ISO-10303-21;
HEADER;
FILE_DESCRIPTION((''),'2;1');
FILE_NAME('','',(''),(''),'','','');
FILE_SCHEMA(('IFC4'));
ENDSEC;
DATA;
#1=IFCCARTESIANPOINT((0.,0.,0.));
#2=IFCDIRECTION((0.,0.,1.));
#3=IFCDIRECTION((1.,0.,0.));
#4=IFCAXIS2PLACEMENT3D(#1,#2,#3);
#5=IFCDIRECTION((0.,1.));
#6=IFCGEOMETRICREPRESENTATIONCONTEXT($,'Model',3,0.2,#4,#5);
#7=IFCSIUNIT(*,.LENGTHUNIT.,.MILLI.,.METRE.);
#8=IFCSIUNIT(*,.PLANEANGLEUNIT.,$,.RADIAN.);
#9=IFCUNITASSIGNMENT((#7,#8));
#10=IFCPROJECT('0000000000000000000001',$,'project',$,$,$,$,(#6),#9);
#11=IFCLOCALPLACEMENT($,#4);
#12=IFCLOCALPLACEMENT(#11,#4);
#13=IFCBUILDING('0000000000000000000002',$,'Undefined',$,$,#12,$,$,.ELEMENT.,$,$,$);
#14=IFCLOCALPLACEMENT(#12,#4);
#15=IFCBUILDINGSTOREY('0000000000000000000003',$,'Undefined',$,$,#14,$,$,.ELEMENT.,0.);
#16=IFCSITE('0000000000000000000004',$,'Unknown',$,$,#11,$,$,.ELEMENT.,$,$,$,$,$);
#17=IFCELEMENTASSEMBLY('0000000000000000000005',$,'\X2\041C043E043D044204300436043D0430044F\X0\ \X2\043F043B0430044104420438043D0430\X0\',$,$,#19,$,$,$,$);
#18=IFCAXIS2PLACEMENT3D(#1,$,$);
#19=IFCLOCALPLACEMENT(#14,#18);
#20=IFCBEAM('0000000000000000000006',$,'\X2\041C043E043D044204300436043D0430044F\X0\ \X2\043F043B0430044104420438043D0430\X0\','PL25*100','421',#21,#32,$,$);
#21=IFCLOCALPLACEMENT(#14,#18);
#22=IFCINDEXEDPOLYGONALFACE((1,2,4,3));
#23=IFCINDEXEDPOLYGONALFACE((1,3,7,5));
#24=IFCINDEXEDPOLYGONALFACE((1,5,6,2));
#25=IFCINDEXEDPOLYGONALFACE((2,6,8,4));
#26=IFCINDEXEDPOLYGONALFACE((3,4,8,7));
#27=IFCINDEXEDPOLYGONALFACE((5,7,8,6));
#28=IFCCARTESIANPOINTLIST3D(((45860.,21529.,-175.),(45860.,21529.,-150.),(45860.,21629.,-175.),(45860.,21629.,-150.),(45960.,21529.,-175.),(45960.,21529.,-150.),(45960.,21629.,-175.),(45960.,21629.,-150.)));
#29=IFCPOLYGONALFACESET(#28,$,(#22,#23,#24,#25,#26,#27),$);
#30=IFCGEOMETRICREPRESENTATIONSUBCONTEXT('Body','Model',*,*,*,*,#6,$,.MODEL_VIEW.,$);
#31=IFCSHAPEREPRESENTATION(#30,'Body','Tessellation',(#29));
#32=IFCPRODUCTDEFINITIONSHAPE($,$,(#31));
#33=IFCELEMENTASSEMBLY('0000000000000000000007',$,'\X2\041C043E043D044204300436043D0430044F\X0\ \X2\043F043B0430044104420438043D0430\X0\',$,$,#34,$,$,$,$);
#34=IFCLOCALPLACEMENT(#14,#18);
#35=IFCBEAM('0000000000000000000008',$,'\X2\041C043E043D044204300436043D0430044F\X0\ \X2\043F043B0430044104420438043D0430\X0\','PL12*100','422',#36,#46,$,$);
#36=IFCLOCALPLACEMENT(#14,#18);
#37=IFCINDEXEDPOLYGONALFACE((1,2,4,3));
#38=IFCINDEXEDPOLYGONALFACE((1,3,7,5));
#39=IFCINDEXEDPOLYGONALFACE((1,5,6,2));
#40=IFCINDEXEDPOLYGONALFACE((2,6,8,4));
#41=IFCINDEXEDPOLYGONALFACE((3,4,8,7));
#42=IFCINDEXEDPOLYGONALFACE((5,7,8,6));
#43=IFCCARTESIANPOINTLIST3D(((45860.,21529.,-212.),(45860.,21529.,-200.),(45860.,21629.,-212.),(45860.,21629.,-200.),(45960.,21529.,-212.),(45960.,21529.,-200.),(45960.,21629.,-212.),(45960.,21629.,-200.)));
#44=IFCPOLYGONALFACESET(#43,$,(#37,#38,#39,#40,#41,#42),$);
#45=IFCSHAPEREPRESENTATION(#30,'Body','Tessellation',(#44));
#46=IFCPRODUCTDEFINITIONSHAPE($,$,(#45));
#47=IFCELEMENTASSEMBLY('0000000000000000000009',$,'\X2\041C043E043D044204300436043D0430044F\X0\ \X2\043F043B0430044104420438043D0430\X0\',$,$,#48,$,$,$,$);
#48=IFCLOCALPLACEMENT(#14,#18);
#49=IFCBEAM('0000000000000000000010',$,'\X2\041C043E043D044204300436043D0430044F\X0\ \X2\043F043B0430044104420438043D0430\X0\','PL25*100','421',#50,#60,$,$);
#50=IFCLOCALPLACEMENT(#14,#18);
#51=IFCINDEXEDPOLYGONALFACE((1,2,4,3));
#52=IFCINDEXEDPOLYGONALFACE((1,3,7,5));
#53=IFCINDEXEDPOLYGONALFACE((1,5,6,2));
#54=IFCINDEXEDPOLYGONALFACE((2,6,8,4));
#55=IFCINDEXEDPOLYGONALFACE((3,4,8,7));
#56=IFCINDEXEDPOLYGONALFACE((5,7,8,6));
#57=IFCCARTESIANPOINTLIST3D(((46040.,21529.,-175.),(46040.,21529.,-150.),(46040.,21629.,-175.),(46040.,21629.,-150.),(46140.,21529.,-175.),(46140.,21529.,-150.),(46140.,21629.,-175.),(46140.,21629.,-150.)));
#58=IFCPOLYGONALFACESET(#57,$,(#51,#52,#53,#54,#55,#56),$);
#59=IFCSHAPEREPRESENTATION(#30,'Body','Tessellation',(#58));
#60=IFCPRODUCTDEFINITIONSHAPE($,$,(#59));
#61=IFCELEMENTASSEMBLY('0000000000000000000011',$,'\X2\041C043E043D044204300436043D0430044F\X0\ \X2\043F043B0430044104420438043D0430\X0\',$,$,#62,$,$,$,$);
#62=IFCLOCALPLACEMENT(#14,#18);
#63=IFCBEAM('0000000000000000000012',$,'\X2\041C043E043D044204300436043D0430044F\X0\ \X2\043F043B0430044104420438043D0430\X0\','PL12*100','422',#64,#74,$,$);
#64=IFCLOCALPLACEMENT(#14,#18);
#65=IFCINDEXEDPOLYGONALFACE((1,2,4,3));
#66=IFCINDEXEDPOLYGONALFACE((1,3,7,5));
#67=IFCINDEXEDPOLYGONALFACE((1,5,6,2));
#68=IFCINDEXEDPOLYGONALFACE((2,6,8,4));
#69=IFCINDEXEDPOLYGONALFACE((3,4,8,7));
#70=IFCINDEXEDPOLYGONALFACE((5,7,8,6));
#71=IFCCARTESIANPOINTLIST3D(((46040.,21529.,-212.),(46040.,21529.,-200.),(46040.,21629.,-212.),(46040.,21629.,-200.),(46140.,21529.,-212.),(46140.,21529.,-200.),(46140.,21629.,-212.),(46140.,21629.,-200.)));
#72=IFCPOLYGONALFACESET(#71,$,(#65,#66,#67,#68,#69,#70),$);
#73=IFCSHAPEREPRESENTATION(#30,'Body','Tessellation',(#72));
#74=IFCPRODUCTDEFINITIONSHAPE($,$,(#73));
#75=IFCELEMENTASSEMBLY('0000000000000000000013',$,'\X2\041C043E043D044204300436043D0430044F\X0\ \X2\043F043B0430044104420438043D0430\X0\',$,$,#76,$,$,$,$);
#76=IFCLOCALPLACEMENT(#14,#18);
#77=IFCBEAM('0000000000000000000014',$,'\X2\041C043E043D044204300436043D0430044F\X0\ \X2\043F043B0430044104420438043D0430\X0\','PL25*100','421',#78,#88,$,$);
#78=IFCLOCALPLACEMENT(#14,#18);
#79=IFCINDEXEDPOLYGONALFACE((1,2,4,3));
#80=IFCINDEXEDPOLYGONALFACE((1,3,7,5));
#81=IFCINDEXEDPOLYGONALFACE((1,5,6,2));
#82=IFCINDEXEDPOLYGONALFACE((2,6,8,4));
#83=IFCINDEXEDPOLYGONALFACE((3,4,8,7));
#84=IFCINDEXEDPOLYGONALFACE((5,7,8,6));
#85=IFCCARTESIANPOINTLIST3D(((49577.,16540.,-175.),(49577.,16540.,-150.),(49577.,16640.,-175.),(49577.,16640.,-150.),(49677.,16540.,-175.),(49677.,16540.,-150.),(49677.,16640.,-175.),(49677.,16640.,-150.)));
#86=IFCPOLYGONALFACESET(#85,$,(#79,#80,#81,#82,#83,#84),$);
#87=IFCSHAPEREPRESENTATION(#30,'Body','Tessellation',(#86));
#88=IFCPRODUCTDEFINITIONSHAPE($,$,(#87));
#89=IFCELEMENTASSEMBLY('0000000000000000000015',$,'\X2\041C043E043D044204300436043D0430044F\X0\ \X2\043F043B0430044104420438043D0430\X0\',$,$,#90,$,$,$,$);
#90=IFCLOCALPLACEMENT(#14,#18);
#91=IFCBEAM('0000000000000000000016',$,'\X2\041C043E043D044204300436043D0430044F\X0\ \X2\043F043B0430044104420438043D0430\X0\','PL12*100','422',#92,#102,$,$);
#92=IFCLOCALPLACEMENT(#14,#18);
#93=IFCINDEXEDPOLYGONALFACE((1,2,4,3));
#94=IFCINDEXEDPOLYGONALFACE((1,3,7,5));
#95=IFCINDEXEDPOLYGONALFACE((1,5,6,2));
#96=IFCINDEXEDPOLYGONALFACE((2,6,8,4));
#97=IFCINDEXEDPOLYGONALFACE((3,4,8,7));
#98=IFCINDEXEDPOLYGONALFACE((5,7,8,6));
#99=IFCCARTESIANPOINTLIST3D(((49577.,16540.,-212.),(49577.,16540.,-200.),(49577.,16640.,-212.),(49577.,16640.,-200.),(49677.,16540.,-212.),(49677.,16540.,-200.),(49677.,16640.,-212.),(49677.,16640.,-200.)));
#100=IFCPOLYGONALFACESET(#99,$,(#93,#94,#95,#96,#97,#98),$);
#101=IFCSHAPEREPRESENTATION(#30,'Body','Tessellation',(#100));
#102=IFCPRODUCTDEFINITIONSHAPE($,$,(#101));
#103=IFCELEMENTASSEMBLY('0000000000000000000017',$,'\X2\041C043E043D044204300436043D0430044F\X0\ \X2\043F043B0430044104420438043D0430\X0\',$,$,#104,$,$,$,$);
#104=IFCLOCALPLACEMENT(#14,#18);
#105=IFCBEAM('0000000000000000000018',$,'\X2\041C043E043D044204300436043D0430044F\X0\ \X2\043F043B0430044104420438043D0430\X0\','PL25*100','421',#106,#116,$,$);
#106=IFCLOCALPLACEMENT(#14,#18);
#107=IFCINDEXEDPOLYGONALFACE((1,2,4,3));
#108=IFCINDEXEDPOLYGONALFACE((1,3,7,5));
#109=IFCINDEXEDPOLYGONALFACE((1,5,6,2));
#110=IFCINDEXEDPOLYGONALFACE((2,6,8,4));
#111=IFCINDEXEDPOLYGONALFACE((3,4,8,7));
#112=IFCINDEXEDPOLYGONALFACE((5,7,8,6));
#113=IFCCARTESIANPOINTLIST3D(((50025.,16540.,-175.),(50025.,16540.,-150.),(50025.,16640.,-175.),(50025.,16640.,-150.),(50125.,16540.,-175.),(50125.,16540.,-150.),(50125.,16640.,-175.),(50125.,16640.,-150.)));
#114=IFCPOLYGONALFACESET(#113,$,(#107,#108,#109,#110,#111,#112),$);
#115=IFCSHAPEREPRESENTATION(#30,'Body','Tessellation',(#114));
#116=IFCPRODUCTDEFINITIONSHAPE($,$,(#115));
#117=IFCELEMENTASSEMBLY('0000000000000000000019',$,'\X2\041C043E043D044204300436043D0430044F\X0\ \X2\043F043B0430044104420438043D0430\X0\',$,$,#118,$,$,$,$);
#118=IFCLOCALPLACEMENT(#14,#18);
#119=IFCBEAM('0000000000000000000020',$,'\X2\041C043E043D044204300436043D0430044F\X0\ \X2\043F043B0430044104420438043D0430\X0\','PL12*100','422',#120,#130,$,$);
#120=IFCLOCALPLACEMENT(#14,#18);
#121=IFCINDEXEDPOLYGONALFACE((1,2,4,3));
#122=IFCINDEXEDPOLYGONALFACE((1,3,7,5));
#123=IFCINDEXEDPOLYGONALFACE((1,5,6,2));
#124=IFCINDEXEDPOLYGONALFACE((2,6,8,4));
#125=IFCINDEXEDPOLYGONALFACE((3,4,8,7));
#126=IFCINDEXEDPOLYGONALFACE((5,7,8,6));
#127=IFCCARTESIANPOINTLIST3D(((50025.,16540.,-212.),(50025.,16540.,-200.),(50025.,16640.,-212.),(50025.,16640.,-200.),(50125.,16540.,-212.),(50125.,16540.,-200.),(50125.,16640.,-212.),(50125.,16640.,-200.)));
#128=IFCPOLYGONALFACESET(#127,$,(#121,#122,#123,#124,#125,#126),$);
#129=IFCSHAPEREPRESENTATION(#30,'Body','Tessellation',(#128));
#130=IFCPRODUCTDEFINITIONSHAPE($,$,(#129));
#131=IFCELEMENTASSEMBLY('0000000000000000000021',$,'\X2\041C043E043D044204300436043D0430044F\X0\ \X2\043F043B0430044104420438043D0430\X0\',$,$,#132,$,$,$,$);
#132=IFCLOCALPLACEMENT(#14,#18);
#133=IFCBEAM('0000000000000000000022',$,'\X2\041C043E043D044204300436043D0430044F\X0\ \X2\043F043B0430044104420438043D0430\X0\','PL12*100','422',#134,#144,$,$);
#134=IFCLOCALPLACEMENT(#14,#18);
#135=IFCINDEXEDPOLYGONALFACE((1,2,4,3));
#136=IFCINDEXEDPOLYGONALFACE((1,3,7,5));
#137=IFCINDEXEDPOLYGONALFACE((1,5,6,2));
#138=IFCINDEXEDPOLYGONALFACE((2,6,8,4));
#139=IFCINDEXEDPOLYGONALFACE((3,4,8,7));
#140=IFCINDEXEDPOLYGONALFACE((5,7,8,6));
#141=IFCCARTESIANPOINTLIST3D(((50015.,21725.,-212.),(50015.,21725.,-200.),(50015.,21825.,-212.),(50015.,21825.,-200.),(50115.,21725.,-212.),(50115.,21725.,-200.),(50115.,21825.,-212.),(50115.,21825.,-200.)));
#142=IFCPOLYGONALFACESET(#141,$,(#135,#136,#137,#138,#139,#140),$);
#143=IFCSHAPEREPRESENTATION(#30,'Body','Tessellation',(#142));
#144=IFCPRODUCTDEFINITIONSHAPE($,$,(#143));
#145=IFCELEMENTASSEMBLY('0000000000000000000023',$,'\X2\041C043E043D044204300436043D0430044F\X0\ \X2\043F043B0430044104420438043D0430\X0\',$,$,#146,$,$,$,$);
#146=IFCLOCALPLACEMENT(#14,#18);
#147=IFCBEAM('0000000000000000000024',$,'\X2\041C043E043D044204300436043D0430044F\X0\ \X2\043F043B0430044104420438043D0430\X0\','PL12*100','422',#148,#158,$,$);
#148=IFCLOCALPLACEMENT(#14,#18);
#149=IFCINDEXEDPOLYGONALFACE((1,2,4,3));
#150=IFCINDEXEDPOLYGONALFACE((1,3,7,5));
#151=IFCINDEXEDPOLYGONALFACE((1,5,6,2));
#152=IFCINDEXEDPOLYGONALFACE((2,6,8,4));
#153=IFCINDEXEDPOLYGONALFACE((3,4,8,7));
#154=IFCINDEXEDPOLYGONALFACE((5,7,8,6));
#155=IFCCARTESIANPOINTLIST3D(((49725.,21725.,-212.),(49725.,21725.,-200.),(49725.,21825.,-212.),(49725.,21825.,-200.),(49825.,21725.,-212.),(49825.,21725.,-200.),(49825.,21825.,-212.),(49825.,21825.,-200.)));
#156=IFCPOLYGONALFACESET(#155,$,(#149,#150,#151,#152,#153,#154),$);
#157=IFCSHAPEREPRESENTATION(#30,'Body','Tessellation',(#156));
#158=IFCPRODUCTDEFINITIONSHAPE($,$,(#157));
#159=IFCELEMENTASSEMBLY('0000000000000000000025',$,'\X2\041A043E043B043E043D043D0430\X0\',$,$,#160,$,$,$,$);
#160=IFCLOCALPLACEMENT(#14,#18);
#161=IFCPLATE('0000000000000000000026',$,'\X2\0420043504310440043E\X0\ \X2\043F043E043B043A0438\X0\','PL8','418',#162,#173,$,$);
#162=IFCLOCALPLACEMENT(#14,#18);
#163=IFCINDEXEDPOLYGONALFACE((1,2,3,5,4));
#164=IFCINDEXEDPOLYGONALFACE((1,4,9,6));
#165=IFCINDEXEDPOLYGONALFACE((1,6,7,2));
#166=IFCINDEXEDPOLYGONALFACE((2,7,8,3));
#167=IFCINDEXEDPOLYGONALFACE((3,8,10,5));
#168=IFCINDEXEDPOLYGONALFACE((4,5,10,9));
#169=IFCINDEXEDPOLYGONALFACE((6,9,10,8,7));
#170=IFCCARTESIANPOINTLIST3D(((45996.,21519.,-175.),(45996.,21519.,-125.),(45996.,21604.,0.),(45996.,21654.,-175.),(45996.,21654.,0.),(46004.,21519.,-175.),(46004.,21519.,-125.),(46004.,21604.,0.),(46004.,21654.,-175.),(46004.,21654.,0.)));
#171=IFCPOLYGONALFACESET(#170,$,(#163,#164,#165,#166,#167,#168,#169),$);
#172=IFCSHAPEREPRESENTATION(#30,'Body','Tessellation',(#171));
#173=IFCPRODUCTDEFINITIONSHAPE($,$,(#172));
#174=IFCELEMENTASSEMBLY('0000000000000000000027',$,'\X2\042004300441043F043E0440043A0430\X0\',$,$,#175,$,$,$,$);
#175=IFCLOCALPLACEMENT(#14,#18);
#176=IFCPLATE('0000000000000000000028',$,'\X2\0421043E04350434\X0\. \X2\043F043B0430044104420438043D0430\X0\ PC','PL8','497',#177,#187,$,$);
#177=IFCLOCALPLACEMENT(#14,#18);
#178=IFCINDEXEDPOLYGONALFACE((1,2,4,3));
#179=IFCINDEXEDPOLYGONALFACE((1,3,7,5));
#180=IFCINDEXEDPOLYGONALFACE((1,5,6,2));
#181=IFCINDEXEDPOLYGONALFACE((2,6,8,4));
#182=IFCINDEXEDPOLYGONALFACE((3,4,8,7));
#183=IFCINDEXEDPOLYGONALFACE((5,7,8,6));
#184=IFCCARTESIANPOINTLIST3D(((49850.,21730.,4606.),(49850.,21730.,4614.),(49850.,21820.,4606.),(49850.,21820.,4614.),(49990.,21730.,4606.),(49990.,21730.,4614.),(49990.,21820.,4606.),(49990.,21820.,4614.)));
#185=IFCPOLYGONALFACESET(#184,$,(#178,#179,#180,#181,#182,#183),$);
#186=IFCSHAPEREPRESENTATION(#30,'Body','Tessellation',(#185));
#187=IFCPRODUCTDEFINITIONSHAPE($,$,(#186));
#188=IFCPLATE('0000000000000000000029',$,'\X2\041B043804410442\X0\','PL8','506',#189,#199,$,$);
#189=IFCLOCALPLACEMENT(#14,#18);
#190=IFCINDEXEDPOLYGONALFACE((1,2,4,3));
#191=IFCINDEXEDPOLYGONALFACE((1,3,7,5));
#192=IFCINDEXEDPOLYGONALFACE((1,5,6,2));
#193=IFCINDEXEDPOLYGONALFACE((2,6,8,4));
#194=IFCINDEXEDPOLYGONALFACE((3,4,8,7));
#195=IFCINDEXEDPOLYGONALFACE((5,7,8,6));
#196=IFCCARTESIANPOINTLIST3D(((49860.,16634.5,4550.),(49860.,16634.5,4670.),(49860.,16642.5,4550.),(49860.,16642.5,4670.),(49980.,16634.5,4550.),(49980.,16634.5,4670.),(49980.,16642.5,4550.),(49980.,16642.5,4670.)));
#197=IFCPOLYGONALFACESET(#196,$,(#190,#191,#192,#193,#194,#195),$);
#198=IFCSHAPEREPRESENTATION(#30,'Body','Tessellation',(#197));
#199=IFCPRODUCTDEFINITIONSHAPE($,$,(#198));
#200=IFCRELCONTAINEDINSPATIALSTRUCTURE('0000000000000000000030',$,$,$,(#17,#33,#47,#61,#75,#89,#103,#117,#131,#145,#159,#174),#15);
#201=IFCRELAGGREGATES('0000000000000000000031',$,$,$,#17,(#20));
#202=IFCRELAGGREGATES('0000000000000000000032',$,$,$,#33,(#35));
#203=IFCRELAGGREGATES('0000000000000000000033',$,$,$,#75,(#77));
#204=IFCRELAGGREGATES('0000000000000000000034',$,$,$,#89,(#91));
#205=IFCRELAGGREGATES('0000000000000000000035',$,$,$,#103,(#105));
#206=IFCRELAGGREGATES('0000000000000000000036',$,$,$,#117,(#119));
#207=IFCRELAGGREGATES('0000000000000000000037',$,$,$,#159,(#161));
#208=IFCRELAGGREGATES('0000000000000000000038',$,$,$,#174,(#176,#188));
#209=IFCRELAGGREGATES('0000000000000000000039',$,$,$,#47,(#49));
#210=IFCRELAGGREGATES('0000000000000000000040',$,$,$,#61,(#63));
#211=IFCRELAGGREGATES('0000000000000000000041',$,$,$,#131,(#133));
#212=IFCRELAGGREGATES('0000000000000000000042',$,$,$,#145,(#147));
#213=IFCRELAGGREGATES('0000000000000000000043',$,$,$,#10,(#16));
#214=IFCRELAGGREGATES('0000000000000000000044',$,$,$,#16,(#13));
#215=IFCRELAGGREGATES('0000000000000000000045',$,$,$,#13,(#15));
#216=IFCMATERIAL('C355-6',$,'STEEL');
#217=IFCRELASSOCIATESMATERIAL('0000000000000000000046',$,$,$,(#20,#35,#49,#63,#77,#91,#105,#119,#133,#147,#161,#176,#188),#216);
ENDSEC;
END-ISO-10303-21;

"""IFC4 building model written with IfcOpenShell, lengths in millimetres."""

from ifc_helpers import new_model, si_unit, direction, frame, origin_with_axes, place, context, subcontext, project, spatial, line, indexed_curve, outline, extrude, material, element, aggregate, save


model = new_model("IFC4")

# Units and contexts
model_context = context("Model", 3, precision=0.2, world=origin_with_axes(), true_north=direction((0.0, 1.0)))
body_context = subcontext(model_context, "Body", "Model", "MODEL_VIEW")
ifc_project = project(units=[si_unit("LENGTHUNIT", "METRE", prefix="MILLI"), si_unit("PLANEANGLEUNIT", "RADIAN")], contexts=[model_context])

# Site, building, storey
site_placement = place(None, origin_with_axes())
site = spatial("IfcSite", under=ifc_project, at=site_placement, Name="Unknown", CompositionType="ELEMENT")
building_placement = place(site_placement, origin_with_axes())
building = spatial("IfcBuilding", under=site, at=building_placement, Name="Undefined", CompositionType="ELEMENT")
storey_placement = place(building_placement, origin_with_axes())
storey = spatial("IfcBuildingStorey", under=building, at=storey_placement, Name="Undefined", CompositionType="ELEMENT", Elevation=0.0)

# Element assemblies, beams
assembly_1_placement = place(storey_placement, frame((45960.0, 21579.0, -162.5), z_axis=(0.0, 0.0, -1.0), x_axis=(-1.0, 0.0, 0.0)))
assembly_1 = element("IfcElementAssembly", 1, at=assembly_1_placement, inside=storey, Name="Монтажная пластина")
ifc_material_1 = material(Name="C355-6", Category="STEEL")
beam_1_placement = place(assembly_1_placement, origin_with_axes())
beam_1 = element("IfcBeam", 2, at=beam_1_placement, material=ifc_material_1, Name="Монтажная пластина", Description="PL25*100", ObjectType="421", context=body_context, shape_type="SolidModel", body=[
    extrude(outline(indexed_curve([(-12.5, -50.0), (12.5, -50.0), (12.5, 50.0), (-12.5, 50.0)], segments=[line(1, 2, 3, 4, 1)])), frame((0.0, 0.0, 0.0), z_axis=(-1.0, 0.0, 0.0), x_axis=(0.0, 0.0, 1.0)), (0.0, 0.0, -1.0), 100.0),
])
aggregate(assembly_1, [beam_1])
assembly_2_placement = place(storey_placement, frame((45960.0, 21579.0, -206.0), z_axis=(0.0, 0.0, -1.0), x_axis=(-1.0, 0.0, 0.0)))
assembly_2 = element("IfcElementAssembly", 3, at=assembly_2_placement, inside=storey, Name="Монтажная пластина")
beam_2_placement = place(assembly_2_placement, origin_with_axes())
beam_2 = element("IfcBeam", 4, at=beam_2_placement, material=ifc_material_1, Name="Монтажная пластина", Description="PL12*100", ObjectType="422", context=body_context, shape_type="SolidModel", body=[
    extrude(outline(indexed_curve([(-6.0, -50.0), (6.0, -50.0), (6.0, 50.0), (-6.0, 50.0)], segments=[line(1, 2, 3, 4, 1)])), frame((0.0, 0.0, 0.0), z_axis=(-1.0, 0.0, 0.0), x_axis=(0.0, 0.0, 1.0)), (0.0, 0.0, -1.0), 100.0),
])
aggregate(assembly_2, [beam_2])
assembly_3_placement = place(storey_placement, frame((46140.0, 21579.0, -162.5), z_axis=(0.0, 0.0, -1.0), x_axis=(-1.0, 0.0, 0.0)))
assembly_3 = element("IfcElementAssembly", 5, at=assembly_3_placement, inside=storey, Name="Монтажная пластина")
beam_3_placement = place(assembly_3_placement, origin_with_axes())
beam_3 = element("IfcBeam", 6, at=beam_3_placement, material=ifc_material_1, Name="Монтажная пластина", Description="PL25*100", ObjectType="421", context=body_context, shape_type="SolidModel", body=[
    extrude(outline(indexed_curve([(-12.5, -50.0), (12.5, -50.0), (12.5, 50.0), (-12.5, 50.0)], segments=[line(1, 2, 3, 4, 1)])), frame((0.0, 0.0, 0.0), z_axis=(-1.0, 0.0, 0.0), x_axis=(0.0, 0.0, 1.0)), (0.0, 0.0, -1.0), 100.0),
])
assembly_4_placement = place(storey_placement, frame((46140.0, 21579.0, -206.0), z_axis=(0.0, 0.0, -1.0), x_axis=(-1.0, 0.0, 0.0)))
assembly_4 = element("IfcElementAssembly", 7, at=assembly_4_placement, inside=storey, Name="Монтажная пластина")
beam_4_placement = place(assembly_4_placement, origin_with_axes())
beam_4 = element("IfcBeam", 8, at=beam_4_placement, material=ifc_material_1, Name="Монтажная пластина", Description="PL12*100", ObjectType="422", context=body_context, shape_type="SolidModel", body=[
    extrude(outline(indexed_curve([(-6.0, -50.0), (6.0, -50.0), (6.0, 50.0), (-6.0, 50.0)], segments=[line(1, 2, 3, 4, 1)])), frame((0.0, 0.0, 0.0), z_axis=(-1.0, 0.0, 0.0), x_axis=(0.0, 0.0, 1.0)), (0.0, 0.0, -1.0), 100.0),
])
assembly_5_placement = place(storey_placement, frame((49627.0, 16640.0, -162.5), z_axis=(0.0, 0.0, -1.0), x_axis=(0.0, -1.0, 0.0)))
assembly_5 = element("IfcElementAssembly", 9, at=assembly_5_placement, inside=storey, Name="Монтажная пластина")
beam_5_placement = place(assembly_5_placement, origin_with_axes())
beam_5 = element("IfcBeam", 10, at=beam_5_placement, material=ifc_material_1, Name="Монтажная пластина", Description="PL25*100", ObjectType="421", context=body_context, shape_type="SolidModel", body=[
    extrude(outline(indexed_curve([(-12.5, -50.0), (12.5, -50.0), (12.5, 50.0), (-12.5, 50.0)], segments=[line(1, 2, 3, 4, 1)])), frame((0.0, 0.0, 0.0), z_axis=(-1.0, 0.0, 0.0), x_axis=(0.0, 0.0, 1.0)), (0.0, 0.0, -1.0), 100.0),
])
aggregate(assembly_5, [beam_5])
assembly_6_placement = place(storey_placement, frame((49627.0, 16640.0, -206.0), z_axis=(0.0, 0.0, -1.0), x_axis=(0.0, -1.0, 0.0)))
assembly_6 = element("IfcElementAssembly", 11, at=assembly_6_placement, inside=storey, Name="Монтажная пластина")
beam_6_placement = place(assembly_6_placement, origin_with_axes())
beam_6 = element("IfcBeam", 12, at=beam_6_placement, material=ifc_material_1, Name="Монтажная пластина", Description="PL12*100", ObjectType="422", context=body_context, shape_type="SolidModel", body=[
    extrude(outline(indexed_curve([(-6.0, -50.0), (6.0, -50.0), (6.0, 50.0), (-6.0, 50.0)], segments=[line(1, 2, 3, 4, 1)])), frame((0.0, 0.0, 0.0), z_axis=(-1.0, 0.0, 0.0), x_axis=(0.0, 0.0, 1.0)), (0.0, 0.0, -1.0), 100.0),
])
aggregate(assembly_6, [beam_6])
assembly_7_placement = place(storey_placement, frame((50075.0, 16640.0, -162.5), z_axis=(0.0, 0.0, -1.0), x_axis=(0.0, -1.0, 0.0)))
assembly_7 = element("IfcElementAssembly", 13, at=assembly_7_placement, inside=storey, Name="Монтажная пластина")
beam_7_placement = place(assembly_7_placement, origin_with_axes())
beam_7 = element("IfcBeam", 14, at=beam_7_placement, material=ifc_material_1, Name="Монтажная пластина", Description="PL25*100", ObjectType="421", context=body_context, shape_type="SolidModel", body=[
    extrude(outline(indexed_curve([(-12.5, -50.0), (12.5, -50.0), (12.5, 50.0), (-12.5, 50.0)], segments=[line(1, 2, 3, 4, 1)])), frame((0.0, 0.0, 0.0), z_axis=(-1.0, 0.0, 0.0), x_axis=(0.0, 0.0, 1.0)), (0.0, 0.0, -1.0), 100.0),
])
aggregate(assembly_7, [beam_7])
assembly_8_placement = place(storey_placement, frame((50075.0, 16640.0, -206.0), z_axis=(0.0, 0.0, -1.0), x_axis=(0.0, -1.0, 0.0)))
assembly_8 = element("IfcElementAssembly", 15, at=assembly_8_placement, inside=storey, Name="Монтажная пластина")
beam_8_placement = place(assembly_8_placement, origin_with_axes())
beam_8 = element("IfcBeam", 16, at=beam_8_placement, material=ifc_material_1, Name="Монтажная пластина", Description="PL12*100", ObjectType="422", context=body_context, shape_type="SolidModel", body=[
    extrude(outline(indexed_curve([(-6.0, -50.0), (6.0, -50.0), (6.0, 50.0), (-6.0, 50.0)], segments=[line(1, 2, 3, 4, 1)])), frame((0.0, 0.0, 0.0), z_axis=(-1.0, 0.0, 0.0), x_axis=(0.0, 0.0, 1.0)), (0.0, 0.0, -1.0), 100.0),
])
aggregate(assembly_8, [beam_8])
assembly_9_placement = place(storey_placement, frame((50015.0, 21775.0, -206.0), z_axis=(0.0, 0.0, -1.0), x_axis=(1.0, 0.0, 0.0)))
assembly_9 = element("IfcElementAssembly", 17, at=assembly_9_placement, inside=storey, Name="Монтажная пластина")
beam_9_placement = place(assembly_9_placement, origin_with_axes())
beam_9 = element("IfcBeam", 18, at=beam_9_placement, material=ifc_material_1, Name="Монтажная пластина", Description="PL12*100", ObjectType="422", context=body_context, shape_type="SolidModel", body=[
    extrude(outline(indexed_curve([(-6.0, -50.0), (6.0, -50.0), (6.0, 50.0), (-6.0, 50.0)], segments=[line(1, 2, 3, 4, 1)])), frame((0.0, 0.0, 0.0), z_axis=(-1.0, 0.0, 0.0), x_axis=(0.0, 0.0, 1.0)), (0.0, 0.0, -1.0), 100.0),
])
assembly_10_placement = place(storey_placement, frame((49725.0, 21775.0, -206.0), z_axis=(0.0, 0.0, -1.0), x_axis=(1.0, 0.0, 0.0)))
assembly_10 = element("IfcElementAssembly", 19, at=assembly_10_placement, inside=storey, Name="Монтажная пластина")
beam_10_placement = place(assembly_10_placement, origin_with_axes())
beam_10 = element("IfcBeam", 20, at=beam_10_placement, material=ifc_material_1, Name="Монтажная пластина", Description="PL12*100", ObjectType="422", context=body_context, shape_type="SolidModel", body=[
    extrude(outline(indexed_curve([(-6.0, -50.0), (6.0, -50.0), (6.0, 50.0), (-6.0, 50.0)], segments=[line(1, 2, 3, 4, 1)])), frame((0.0, 0.0, 0.0), z_axis=(-1.0, 0.0, 0.0), x_axis=(0.0, 0.0, 1.0)), (0.0, 0.0, -1.0), 100.0),
])

# Element assembly, plate
assembly_11_placement = place(storey_placement, frame((46000.0, 21827.0, -200.0), z_axis=(-1.0, 0.0, 0.0), x_axis=(0.0, 0.0, 1.0)))
assembly_11 = element("IfcElementAssembly", 21, at=assembly_11_placement, inside=storey, Name="Колонна")
plate_1_placement = place(assembly_11_placement, frame((25.0, -173.0, 0.0), z_axis=(0.0, 0.0, 1.0), x_axis=(0.0, -1.0, 0.0)))
plate_1 = element("IfcPlate", 22, at=plate_1_placement, material=ifc_material_1, Name="Ребро полки", Description="PL8", ObjectType="418", context=body_context, shape_type="SolidModel", body=[
    extrude(outline(indexed_curve([(0.0, 0.0), (135.0, 0.0), (135.0, 50.0), (50.0, 175.0), (0.0, 175.0)], segments=[line(1, 2, 3, 4, 5, 1)])), frame((0.0, 0.0, 4.0), z_axis=(0.0, 0.0, 1.0), x_axis=(1.0, 0.0, 0.0)), (0.0, 0.0, -1.0), 8.0),
])
aggregate(assembly_11, [plate_1])

# Element assembly, plates
assembly_12_placement = place(storey_placement, frame((49920.0, 16500.0, 4610.0), z_axis=(0.0, 0.0, -1.0), x_axis=(0.0, 1.0, 0.0)))
assembly_12 = element("IfcElementAssembly", 23, at=assembly_12_placement, inside=storey, Name="Распорка")
plate_2_placement = place(assembly_12_placement, frame((5230.0, 70.0, 0.0), z_axis=(0.0, 0.0, -1.0), x_axis=(1.0, 0.0, 0.0)))
plate_2 = element("IfcPlate", 24, at=plate_2_placement, material=ifc_material_1, Name="Соед. пластина PC", Description="PL8", ObjectType="497", context=body_context, shape_type="SolidModel", body=[
    extrude(outline(indexed_curve([(0.0, 0.0), (90.0, 0.0), (90.0, 140.0), (0.0, 140.0)], segments=[line(1, 2, 3, 4, 1)])), frame((0.0, 0.0, 4.0), z_axis=(0.0, 0.0, 1.0), x_axis=(1.0, 0.0, 0.0)), (0.0, 0.0, -1.0), 8.0),
])
plate_3_placement = place(assembly_12_placement, frame((138.5, 60.0, 60.0), z_axis=(-1.0, 0.0, 0.0), x_axis=(0.0, 0.0, -1.0)))
plate_3 = element("IfcPlate", 25, at=plate_3_placement, material=ifc_material_1, Name="Лист", Description="PL8", ObjectType="506", context=body_context, shape_type="SolidModel", body=[
    extrude(outline(indexed_curve([(0.0, 0.0), (120.0, 0.0), (120.0, 120.0), (0.0, 120.0)], segments=[line(1, 2, 3, 4, 1)])), frame((0.0, 0.0, 4.0), z_axis=(0.0, 0.0, 1.0), x_axis=(1.0, 0.0, 0.0)), (0.0, 0.0, -1.0), 8.0),
])
aggregate(assembly_12, [plate_2, plate_3])

aggregate(assembly_3, [beam_3])
aggregate(assembly_4, [beam_4])
aggregate(assembly_9, [beam_9])
aggregate(assembly_10, [beam_10])

save(model, "model.ifc")
